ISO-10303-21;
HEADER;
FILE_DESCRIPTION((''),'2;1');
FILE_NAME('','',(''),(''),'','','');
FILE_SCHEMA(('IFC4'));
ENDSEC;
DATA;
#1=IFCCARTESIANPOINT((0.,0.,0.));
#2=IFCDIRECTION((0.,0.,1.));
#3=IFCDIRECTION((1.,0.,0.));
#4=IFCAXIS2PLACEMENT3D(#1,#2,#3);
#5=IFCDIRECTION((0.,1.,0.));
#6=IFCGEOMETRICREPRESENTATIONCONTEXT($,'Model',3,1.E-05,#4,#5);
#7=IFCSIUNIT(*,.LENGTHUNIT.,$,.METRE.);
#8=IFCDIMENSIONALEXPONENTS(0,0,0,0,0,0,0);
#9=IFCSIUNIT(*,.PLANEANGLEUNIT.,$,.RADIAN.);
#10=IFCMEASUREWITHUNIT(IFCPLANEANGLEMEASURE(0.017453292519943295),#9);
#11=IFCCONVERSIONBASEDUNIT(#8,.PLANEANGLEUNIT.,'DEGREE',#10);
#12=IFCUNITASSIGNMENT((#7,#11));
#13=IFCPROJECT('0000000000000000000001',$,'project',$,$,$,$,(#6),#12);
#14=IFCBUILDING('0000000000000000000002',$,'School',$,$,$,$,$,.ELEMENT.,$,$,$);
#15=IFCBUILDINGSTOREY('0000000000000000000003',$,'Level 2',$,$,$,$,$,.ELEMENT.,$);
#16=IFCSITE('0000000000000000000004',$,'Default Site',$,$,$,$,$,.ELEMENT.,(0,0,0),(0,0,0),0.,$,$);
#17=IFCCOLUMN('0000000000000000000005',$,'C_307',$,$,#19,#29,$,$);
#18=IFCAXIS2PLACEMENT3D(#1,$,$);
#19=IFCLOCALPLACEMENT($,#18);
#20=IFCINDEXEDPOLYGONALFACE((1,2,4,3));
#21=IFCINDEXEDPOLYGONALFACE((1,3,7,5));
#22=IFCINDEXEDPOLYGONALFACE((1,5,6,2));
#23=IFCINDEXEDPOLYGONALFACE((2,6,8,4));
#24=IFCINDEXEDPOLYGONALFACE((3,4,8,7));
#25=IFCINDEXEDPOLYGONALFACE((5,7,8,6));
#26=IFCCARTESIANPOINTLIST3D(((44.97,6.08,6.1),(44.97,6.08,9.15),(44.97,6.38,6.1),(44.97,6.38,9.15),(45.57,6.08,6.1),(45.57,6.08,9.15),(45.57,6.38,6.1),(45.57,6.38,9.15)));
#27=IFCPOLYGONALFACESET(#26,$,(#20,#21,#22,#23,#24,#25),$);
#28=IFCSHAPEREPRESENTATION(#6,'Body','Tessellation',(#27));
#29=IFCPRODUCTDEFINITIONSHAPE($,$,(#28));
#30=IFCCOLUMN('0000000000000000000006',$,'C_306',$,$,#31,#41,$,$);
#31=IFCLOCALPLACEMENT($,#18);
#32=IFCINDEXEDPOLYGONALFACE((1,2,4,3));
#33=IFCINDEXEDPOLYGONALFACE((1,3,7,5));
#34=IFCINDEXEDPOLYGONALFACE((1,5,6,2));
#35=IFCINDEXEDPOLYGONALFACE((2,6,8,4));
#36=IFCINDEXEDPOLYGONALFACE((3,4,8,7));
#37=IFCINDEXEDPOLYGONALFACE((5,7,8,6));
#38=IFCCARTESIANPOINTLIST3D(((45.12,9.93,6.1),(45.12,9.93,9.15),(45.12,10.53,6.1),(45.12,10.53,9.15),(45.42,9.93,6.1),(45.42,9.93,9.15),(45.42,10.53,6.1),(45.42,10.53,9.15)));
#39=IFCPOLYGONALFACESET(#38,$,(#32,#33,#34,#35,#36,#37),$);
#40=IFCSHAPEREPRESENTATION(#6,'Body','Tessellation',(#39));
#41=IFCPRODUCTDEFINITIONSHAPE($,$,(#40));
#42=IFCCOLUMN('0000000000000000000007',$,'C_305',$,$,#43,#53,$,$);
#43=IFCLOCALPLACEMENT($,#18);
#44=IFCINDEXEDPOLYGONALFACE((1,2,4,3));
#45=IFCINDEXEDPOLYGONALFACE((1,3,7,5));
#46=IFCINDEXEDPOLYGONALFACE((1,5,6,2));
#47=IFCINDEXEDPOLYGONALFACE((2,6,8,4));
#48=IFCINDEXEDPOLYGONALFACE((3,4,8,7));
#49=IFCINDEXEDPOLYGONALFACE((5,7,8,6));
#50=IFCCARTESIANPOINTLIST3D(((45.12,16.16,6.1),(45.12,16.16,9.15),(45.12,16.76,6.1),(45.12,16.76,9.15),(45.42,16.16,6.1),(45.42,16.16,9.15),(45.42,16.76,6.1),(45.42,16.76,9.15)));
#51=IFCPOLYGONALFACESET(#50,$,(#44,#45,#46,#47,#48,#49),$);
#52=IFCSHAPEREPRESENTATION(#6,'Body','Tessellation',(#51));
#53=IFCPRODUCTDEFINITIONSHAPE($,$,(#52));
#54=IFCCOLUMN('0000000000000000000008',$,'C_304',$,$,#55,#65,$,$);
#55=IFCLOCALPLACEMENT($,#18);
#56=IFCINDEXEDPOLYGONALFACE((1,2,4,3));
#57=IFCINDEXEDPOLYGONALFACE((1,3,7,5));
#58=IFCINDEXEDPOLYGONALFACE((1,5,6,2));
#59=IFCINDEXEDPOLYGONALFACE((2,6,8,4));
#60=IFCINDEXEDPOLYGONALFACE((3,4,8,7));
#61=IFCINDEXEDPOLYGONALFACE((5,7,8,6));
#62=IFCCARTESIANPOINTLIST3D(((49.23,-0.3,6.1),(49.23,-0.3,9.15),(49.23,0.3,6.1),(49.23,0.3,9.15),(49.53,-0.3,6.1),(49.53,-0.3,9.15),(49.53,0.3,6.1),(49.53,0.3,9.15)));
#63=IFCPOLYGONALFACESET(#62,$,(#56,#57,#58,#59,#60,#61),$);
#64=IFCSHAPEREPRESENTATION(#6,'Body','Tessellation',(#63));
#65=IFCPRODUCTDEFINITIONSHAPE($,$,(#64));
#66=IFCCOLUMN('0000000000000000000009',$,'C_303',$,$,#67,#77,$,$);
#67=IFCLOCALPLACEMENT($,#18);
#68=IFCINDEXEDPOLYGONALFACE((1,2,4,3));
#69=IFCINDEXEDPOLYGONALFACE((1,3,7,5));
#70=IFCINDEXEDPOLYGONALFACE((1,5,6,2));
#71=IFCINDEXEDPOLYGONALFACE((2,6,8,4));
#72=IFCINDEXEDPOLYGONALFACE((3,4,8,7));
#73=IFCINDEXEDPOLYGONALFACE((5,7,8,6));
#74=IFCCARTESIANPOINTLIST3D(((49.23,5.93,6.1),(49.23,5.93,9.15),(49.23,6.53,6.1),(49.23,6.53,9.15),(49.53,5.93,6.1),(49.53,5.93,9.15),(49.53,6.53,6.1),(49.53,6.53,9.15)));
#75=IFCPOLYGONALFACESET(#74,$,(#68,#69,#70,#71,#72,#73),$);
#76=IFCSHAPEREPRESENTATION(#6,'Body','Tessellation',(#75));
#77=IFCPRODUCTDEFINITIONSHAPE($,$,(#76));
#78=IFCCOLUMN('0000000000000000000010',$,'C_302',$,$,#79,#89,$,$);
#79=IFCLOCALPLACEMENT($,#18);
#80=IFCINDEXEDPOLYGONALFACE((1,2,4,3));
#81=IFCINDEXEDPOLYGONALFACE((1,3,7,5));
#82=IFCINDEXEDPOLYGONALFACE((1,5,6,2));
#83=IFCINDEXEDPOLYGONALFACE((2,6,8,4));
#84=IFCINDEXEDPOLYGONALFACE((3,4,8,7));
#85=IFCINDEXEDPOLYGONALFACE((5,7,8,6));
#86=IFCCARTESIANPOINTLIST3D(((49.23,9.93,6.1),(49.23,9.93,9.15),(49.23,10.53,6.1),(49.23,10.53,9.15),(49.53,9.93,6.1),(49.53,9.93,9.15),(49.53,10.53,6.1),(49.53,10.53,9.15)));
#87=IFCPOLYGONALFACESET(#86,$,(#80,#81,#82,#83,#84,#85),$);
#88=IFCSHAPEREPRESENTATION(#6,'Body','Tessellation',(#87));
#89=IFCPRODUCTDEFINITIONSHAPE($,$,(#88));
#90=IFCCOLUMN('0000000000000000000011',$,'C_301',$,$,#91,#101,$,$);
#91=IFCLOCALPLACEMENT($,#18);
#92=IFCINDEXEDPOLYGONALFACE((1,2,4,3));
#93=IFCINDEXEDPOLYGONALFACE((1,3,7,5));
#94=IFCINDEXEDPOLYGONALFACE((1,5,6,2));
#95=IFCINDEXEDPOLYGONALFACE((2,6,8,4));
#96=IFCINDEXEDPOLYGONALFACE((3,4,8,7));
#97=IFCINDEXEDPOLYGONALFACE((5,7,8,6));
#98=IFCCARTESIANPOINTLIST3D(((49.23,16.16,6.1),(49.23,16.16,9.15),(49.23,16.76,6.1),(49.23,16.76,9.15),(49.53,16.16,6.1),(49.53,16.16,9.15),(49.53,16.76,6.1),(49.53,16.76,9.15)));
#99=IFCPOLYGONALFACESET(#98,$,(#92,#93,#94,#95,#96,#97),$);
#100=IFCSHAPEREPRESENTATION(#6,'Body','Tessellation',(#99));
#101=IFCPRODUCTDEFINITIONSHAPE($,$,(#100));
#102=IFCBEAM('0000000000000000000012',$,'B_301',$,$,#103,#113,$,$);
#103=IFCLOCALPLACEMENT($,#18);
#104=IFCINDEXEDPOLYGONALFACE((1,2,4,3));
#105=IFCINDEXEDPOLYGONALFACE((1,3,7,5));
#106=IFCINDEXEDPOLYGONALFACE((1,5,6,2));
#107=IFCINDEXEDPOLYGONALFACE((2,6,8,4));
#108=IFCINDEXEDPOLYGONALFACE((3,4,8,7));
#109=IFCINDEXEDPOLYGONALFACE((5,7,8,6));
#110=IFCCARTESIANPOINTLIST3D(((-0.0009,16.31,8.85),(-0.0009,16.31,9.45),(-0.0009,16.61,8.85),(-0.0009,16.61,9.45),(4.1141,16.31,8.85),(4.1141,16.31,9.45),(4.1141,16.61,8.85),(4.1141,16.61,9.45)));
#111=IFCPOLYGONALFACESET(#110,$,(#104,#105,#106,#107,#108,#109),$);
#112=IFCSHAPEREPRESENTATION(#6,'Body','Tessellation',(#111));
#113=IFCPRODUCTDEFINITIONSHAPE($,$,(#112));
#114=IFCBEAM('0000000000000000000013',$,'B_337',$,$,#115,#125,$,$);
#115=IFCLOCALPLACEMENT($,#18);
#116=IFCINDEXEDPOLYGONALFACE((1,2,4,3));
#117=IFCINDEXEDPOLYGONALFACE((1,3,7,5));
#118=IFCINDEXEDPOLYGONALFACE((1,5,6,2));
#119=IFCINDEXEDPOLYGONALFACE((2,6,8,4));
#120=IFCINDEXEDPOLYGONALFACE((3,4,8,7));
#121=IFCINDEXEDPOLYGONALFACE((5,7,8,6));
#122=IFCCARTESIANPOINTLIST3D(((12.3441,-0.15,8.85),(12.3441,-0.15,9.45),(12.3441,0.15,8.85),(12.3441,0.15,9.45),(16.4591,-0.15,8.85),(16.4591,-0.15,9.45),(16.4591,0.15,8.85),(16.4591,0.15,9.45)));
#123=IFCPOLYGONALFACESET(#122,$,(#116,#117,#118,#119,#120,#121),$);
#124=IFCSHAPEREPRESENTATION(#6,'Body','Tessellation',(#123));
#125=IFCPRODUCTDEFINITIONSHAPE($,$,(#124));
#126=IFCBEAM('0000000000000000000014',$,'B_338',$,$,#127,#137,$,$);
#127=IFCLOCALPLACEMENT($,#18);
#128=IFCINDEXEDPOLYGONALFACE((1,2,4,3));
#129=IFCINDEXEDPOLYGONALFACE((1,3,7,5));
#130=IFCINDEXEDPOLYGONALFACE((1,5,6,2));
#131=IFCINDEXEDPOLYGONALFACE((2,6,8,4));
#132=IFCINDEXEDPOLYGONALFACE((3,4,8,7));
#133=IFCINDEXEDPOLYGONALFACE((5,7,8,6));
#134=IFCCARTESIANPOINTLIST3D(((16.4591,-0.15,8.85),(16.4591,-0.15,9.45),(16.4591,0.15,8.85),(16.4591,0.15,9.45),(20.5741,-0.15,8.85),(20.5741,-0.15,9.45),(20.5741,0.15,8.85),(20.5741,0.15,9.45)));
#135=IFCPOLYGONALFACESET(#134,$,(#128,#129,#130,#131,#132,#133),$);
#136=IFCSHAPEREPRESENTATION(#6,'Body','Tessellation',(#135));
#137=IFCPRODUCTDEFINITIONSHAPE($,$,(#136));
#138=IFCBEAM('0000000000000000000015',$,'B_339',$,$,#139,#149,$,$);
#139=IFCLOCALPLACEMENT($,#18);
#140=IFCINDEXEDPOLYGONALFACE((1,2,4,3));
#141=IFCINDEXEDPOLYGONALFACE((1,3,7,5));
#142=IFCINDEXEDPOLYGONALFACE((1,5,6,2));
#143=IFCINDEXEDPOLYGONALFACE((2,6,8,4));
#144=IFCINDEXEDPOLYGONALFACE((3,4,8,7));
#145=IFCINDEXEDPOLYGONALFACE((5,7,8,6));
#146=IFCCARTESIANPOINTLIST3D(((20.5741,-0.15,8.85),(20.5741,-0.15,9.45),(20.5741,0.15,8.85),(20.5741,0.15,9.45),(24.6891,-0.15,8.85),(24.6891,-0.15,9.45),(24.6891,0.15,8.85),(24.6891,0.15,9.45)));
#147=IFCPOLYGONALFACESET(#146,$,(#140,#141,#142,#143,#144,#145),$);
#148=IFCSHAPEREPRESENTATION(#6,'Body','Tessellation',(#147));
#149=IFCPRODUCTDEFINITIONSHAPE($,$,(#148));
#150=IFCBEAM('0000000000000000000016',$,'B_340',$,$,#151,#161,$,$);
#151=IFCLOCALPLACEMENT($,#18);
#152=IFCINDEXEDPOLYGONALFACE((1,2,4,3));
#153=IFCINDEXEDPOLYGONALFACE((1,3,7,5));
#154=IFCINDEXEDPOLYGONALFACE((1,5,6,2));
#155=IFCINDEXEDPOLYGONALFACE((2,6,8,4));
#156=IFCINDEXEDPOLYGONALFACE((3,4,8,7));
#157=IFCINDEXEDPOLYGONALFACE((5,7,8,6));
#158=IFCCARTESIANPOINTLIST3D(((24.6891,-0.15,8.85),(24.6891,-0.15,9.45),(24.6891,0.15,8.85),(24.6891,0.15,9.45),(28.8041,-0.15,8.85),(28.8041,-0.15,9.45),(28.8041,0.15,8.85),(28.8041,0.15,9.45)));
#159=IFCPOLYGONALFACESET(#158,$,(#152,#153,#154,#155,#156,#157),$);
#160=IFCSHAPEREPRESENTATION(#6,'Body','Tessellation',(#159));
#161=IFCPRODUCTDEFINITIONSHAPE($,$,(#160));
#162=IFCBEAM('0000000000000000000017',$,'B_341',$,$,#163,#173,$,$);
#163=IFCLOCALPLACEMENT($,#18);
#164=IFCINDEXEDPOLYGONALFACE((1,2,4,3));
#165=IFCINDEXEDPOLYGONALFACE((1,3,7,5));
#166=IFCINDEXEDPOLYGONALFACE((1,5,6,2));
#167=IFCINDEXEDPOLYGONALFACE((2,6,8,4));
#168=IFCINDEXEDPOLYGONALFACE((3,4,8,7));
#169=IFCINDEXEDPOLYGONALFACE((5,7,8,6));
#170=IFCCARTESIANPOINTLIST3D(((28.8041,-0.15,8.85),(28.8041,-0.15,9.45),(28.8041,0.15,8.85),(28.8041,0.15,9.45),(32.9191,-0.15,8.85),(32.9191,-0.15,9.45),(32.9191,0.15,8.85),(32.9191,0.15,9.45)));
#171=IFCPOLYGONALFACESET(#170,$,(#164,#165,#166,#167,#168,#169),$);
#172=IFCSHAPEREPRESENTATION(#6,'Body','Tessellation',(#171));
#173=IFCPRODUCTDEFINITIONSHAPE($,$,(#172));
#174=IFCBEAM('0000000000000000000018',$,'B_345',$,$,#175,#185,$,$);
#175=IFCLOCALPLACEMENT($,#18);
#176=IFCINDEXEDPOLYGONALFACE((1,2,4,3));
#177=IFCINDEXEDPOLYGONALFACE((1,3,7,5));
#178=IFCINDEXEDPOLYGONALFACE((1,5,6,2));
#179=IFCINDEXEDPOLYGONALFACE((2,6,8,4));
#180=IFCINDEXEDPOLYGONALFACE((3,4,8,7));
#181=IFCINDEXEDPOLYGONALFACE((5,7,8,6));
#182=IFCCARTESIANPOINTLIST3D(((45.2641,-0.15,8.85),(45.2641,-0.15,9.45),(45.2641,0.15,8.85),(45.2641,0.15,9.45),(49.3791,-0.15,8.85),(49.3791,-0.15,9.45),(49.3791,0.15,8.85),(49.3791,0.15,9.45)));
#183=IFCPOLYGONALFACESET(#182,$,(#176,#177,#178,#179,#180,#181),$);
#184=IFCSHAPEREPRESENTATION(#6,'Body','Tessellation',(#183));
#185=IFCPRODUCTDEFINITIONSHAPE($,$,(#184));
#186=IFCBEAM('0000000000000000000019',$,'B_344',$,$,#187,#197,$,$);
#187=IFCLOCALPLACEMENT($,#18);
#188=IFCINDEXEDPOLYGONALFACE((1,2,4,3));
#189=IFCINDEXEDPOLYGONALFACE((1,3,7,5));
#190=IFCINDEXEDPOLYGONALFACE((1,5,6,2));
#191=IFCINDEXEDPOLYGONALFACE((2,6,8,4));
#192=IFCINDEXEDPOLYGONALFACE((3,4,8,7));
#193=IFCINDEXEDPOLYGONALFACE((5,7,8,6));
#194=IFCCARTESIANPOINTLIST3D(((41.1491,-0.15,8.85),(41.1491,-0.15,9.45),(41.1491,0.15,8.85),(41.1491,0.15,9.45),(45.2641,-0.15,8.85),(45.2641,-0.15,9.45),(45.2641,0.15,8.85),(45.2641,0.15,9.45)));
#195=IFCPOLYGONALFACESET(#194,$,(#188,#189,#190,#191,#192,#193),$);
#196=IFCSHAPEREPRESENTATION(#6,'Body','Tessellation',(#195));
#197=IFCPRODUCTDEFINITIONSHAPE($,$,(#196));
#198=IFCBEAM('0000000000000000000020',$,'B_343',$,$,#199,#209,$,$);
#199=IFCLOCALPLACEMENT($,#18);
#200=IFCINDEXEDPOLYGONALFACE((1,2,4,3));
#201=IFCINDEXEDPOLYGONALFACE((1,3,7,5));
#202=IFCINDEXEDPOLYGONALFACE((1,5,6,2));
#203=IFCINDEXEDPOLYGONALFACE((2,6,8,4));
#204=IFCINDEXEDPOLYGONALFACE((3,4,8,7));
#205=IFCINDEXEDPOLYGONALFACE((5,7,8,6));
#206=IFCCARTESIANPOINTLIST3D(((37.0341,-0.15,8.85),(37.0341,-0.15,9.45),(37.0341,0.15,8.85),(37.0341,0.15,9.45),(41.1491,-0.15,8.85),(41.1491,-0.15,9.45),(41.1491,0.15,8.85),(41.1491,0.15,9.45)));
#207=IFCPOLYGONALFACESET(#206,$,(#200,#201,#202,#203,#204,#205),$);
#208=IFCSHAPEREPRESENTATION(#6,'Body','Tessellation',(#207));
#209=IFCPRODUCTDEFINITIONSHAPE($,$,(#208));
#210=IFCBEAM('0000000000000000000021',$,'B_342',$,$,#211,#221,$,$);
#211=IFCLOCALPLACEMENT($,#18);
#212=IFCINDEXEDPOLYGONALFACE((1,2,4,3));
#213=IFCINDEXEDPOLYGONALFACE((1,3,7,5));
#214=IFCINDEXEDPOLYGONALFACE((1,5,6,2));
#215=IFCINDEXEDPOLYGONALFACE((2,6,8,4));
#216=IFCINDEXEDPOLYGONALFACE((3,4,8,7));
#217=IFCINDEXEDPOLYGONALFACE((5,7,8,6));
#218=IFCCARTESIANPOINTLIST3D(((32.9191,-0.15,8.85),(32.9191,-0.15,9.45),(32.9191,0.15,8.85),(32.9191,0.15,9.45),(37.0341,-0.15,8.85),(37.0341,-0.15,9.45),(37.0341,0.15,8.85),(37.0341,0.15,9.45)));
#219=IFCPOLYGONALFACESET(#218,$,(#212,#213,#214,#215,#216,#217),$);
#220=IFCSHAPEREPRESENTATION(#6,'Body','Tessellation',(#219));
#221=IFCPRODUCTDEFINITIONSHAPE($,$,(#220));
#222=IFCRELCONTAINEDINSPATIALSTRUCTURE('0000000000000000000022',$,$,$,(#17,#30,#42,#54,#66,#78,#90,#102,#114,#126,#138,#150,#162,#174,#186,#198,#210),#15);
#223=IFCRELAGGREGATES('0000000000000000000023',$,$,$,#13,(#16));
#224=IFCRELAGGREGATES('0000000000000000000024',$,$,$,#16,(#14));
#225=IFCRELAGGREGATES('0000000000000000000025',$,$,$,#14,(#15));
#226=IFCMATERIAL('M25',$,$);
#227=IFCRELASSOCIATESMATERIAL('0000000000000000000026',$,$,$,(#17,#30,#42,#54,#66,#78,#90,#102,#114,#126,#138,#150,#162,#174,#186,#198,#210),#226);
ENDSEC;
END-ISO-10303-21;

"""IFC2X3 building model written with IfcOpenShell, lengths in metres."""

from ifc_helpers import new_model, entity, si_unit, converted_unit, direction, frame, frame_2d, origin_with_axes, place, context, project, spatial, rectangle, extrude, material, element, save


model = new_model("IFC2X3")

# Units and contexts
model_context = context("Model", 3, precision=1e-05, world=origin_with_axes(), true_north=direction((0.0, 1.0, 0.0)))
ifc_project = project(units=[si_unit("LENGTHUNIT", "METRE"), converted_unit("PLANEANGLEUNIT", "DEGREE", entity("IfcPlaneAngleMeasure", 0.017453292519943295), si_unit("PLANEANGLEUNIT", "RADIAN"), dimensions=[0, 0, 0, 0, 0, 0, 0])], contexts=[model_context])

# Site, building, storey
site = spatial("IfcSite", under=ifc_project, Name="Default Site", CompositionType="ELEMENT", RefLatitude=(0, 0, 0), RefLongitude=(0, 0, 0), RefElevation=0.0)
building = spatial("IfcBuilding", under=site, Name="School", CompositionType="ELEMENT")
storey = spatial("IfcBuildingStorey", under=building, Name="Level 2", CompositionType="ELEMENT")

# Columns
ifc_material = material(Name="M25")
placement = place(None, origin_with_axes())
element("IfcColumn", 1, at=placement, inside=storey, material=ifc_material, Name="C_307", context=model_context, shape_type="SweptSolid", body=[
    extrude(rectangle(XDim=0.6, YDim=0.3, at=frame_2d((0.0, 0.0), x_axis=(1.0, 0.0, 0.0))), frame((45.27, 6.23, 6.1), z_axis=(0.0, 0.0, 1.0), x_axis=(1.0, 0.0, 0.0)), (0.0, 0.0, 1.0), 3.05),
])
element("IfcColumn", 2, at=placement, inside=storey, material=ifc_material, Name="C_306", context=model_context, shape_type="SweptSolid", body=[
    extrude(rectangle(XDim=0.3, YDim=0.6, at=frame_2d((0.0, 0.0), x_axis=(1.0, 0.0, 0.0))), frame((45.27, 10.23, 6.1), z_axis=(0.0, 0.0, 1.0), x_axis=(1.0, 0.0, 0.0)), (0.0, 0.0, 1.0), 3.05),
])
element("IfcColumn", 3, at=placement, inside=storey, material=ifc_material, Name="C_305", context=model_context, shape_type="SweptSolid", body=[
    extrude(rectangle(XDim=0.3, YDim=0.6, at=frame_2d((0.0, 0.0), x_axis=(1.0, 0.0, 0.0))), frame((45.27, 16.46, 6.1), z_axis=(0.0, 0.0, 1.0), x_axis=(1.0, 0.0, 0.0)), (0.0, 0.0, 1.0), 3.05),
])
element("IfcColumn", 4, at=placement, inside=storey, material=ifc_material, Name="C_304", context=model_context, shape_type="SweptSolid", body=[
    extrude(rectangle(XDim=0.3, YDim=0.6, at=frame_2d((0.0, 0.0), x_axis=(1.0, 0.0, 0.0))), frame((49.38, 0.0, 6.1), z_axis=(0.0, 0.0, 1.0), x_axis=(1.0, 0.0, 0.0)), (0.0, 0.0, 1.0), 3.05),
])
element("IfcColumn", 5, at=placement, inside=storey, material=ifc_material, Name="C_303", context=model_context, shape_type="SweptSolid", body=[
    extrude(rectangle(XDim=0.3, YDim=0.6, at=frame_2d((0.0, 0.0), x_axis=(1.0, 0.0, 0.0))), frame((49.38, 6.23, 6.1), z_axis=(0.0, 0.0, 1.0), x_axis=(1.0, 0.0, 0.0)), (0.0, 0.0, 1.0), 3.05),
])
element("IfcColumn", 6, at=placement, inside=storey, material=ifc_material, Name="C_302", context=model_context, shape_type="SweptSolid", body=[
    extrude(rectangle(XDim=0.3, YDim=0.6, at=frame_2d((0.0, 0.0), x_axis=(1.0, 0.0, 0.0))), frame((49.38, 10.23, 6.1), z_axis=(0.0, 0.0, 1.0), x_axis=(1.0, 0.0, 0.0)), (0.0, 0.0, 1.0), 3.05),
])
element("IfcColumn", 7, at=placement, inside=storey, material=ifc_material, Name="C_301", context=model_context, shape_type="SweptSolid", body=[
    extrude(rectangle(XDim=0.3, YDim=0.6, at=frame_2d((0.0, 0.0), x_axis=(1.0, 0.0, 0.0))), frame((49.38, 16.46, 6.1), z_axis=(0.0, 0.0, 1.0), x_axis=(1.0, 0.0, 0.0)), (0.0, 0.0, 1.0), 3.05),
])

# Beams
element("IfcBeam", 8, at=placement, inside=storey, material=ifc_material, Name="B_301", context=model_context, shape_type="SweptSolid", body=[
    extrude(rectangle(XDim=0.3, YDim=0.6, at=frame_2d((0.0, 0.0), x_axis=(0.0, 1.0, 0.0))), frame((-0.0009, 16.46, 9.15), z_axis=(1.0, 0.0, 0.0), x_axis=(0.0, 0.0, -1.0)), (0.0, 0.0, 1.0), 4.115),
])
element("IfcBeam", 9, at=placement, inside=storey, material=ifc_material, Name="B_337", context=model_context, shape_type="SweptSolid", body=[
    extrude(rectangle(XDim=0.3, YDim=0.6, at=frame_2d((0.0, 0.0), x_axis=(0.0, 1.0, 0.0))), frame((12.3441, 0.0, 9.15), z_axis=(1.0, 0.0, 0.0), x_axis=(0.0, 0.0, -1.0)), (0.0, 0.0, 1.0), 4.115),
])
element("IfcBeam", 10, at=placement, inside=storey, material=ifc_material, Name="B_338", context=model_context, shape_type="SweptSolid", body=[
    extrude(rectangle(XDim=0.3, YDim=0.6, at=frame_2d((0.0, 0.0), x_axis=(0.0, 1.0, 0.0))), frame((16.4591, 0.0, 9.15), z_axis=(1.0, 0.0, 0.0), x_axis=(0.0, 0.0, -1.0)), (0.0, 0.0, 1.0), 4.115),
])
element("IfcBeam", 11, at=placement, inside=storey, material=ifc_material, Name="B_339", context=model_context, shape_type="SweptSolid", body=[
    extrude(rectangle(XDim=0.3, YDim=0.6, at=frame_2d((0.0, 0.0), x_axis=(0.0, 1.0, 0.0))), frame((20.5741, 0.0, 9.15), z_axis=(1.0, 0.0, 0.0), x_axis=(0.0, 0.0, -1.0)), (0.0, 0.0, 1.0), 4.115),
])
element("IfcBeam", 12, at=placement, inside=storey, material=ifc_material, Name="B_340", context=model_context, shape_type="SweptSolid", body=[
    extrude(rectangle(XDim=0.3, YDim=0.6, at=frame_2d((0.0, 0.0), x_axis=(0.0, 1.0, 0.0))), frame((24.6891, 0.0, 9.15), z_axis=(1.0, 0.0, 0.0), x_axis=(0.0, 0.0, -1.0)), (0.0, 0.0, 1.0), 4.115),
])
element("IfcBeam", 13, at=placement, inside=storey, material=ifc_material, Name="B_341", context=model_context, shape_type="SweptSolid", body=[
    extrude(rectangle(XDim=0.3, YDim=0.6, at=frame_2d((0.0, 0.0), x_axis=(0.0, 1.0, 0.0))), frame((28.8041, 0.0, 9.15), z_axis=(1.0, 0.0, 0.0), x_axis=(0.0, 0.0, -1.0)), (0.0, 0.0, 1.0), 4.115),
])
element("IfcBeam", 14, at=placement, inside=storey, material=ifc_material, Name="B_345", context=model_context, shape_type="SweptSolid", body=[
    extrude(rectangle(XDim=0.3, YDim=0.6, at=frame_2d((0.0, 0.0), x_axis=(0.0, 1.0, 0.0))), frame((45.2641, 0.0, 9.15), z_axis=(1.0, 0.0, 0.0), x_axis=(0.0, 0.0, -1.0)), (0.0, 0.0, 1.0), 4.115),
])
element("IfcBeam", 15, at=placement, inside=storey, material=ifc_material, Name="B_344", context=model_context, shape_type="SweptSolid", body=[
    extrude(rectangle(XDim=0.3, YDim=0.6, at=frame_2d((0.0, 0.0), x_axis=(0.0, 1.0, 0.0))), frame((41.1491, 0.0, 9.15), z_axis=(1.0, 0.0, 0.0), x_axis=(0.0, 0.0, -1.0)), (0.0, 0.0, 1.0), 4.115),
])
element("IfcBeam", 16, at=placement, inside=storey, material=ifc_material, Name="B_343", context=model_context, shape_type="SweptSolid", body=[
    extrude(rectangle(XDim=0.3, YDim=0.6, at=frame_2d((0.0, 0.0), x_axis=(0.0, 1.0, 0.0))), frame((37.0341, 0.0, 9.15), z_axis=(1.0, 0.0, 0.0), x_axis=(0.0, 0.0, -1.0)), (0.0, 0.0, 1.0), 4.115),
])
element("IfcBeam", 17, at=placement, inside=storey, material=ifc_material, Name="B_342", context=model_context, shape_type="SweptSolid", body=[
    extrude(rectangle(XDim=0.3, YDim=0.6, at=frame_2d((0.0, 0.0), x_axis=(0.0, 1.0, 0.0))), frame((32.9191, 0.0, 9.15), z_axis=(1.0, 0.0, 0.0), x_axis=(0.0, 0.0, -1.0)), (0.0, 0.0, 1.0), 4.115),
])

save(model, "model.ifc")
